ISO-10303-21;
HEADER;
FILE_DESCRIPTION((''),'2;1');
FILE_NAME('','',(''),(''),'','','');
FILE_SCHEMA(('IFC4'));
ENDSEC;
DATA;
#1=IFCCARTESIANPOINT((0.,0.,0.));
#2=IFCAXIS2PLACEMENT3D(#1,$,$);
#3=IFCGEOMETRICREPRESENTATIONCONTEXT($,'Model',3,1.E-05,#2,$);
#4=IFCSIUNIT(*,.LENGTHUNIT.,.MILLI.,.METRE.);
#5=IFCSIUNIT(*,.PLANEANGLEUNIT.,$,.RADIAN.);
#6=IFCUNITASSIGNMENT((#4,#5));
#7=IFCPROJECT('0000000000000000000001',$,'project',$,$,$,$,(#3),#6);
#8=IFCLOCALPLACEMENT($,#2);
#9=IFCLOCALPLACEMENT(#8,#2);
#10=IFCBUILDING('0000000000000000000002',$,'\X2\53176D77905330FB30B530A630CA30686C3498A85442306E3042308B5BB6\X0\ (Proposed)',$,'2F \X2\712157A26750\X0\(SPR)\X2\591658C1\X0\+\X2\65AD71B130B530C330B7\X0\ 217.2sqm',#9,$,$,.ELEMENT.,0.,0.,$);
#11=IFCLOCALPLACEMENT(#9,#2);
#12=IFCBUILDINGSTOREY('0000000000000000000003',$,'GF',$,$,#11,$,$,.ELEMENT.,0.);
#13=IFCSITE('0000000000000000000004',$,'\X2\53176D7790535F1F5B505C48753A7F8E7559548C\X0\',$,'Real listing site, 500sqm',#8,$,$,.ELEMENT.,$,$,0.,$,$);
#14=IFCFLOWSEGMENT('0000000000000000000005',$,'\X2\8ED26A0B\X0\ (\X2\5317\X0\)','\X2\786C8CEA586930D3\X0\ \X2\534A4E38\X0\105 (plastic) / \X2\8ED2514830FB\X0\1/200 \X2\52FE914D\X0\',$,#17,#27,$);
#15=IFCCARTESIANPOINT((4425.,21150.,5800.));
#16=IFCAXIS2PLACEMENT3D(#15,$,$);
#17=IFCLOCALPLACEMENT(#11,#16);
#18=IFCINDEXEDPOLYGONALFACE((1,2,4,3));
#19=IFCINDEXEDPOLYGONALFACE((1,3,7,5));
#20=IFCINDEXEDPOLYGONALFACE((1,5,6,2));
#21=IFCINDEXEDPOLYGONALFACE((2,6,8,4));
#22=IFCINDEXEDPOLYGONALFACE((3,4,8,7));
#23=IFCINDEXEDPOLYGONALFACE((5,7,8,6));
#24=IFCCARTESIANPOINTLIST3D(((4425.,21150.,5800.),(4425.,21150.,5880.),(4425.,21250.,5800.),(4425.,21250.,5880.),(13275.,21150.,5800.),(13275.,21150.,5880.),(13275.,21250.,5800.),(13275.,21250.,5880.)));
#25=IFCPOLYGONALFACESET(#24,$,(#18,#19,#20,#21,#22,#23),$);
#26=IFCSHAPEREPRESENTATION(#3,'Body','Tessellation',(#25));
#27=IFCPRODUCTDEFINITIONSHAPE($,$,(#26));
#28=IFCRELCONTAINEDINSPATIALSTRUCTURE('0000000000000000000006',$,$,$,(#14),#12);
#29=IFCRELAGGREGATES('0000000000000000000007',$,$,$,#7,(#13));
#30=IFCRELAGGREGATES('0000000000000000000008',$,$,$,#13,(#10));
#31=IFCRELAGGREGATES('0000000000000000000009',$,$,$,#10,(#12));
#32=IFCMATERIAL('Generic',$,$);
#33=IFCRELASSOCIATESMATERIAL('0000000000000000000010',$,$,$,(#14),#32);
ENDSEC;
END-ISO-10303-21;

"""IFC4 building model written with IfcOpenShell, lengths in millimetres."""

from ifc_helpers import new_model, si_unit, frame, frame_2d, origin, place, context, project, spatial, rectangle, extrude, material, element, save


model = new_model("IFC4")

# Units and contexts
model_context = context("Model", 3, precision=1e-05, world=origin())
ifc_project = project(units=[si_unit("LENGTHUNIT", "METRE", prefix="MILLI"), si_unit("PLANEANGLEUNIT", "RADIAN")], contexts=[model_context])

# Site, building, storey
site_placement = place(None, origin())
site = spatial("IfcSite", under=ifc_project, at=site_placement, Name="北海道弟子屈町美留和", ObjectType="Real listing site, 500sqm", CompositionType="ELEMENT", RefElevation=0.0)
building_placement = place(site_placement, origin())
building = spatial("IfcBuilding", under=site, at=building_placement, Name="北海道・サウナと水風呂のある家 (Proposed)", ObjectType="2F 無垢材(SPR)外壁+断熱サッシ 217.2sqm", CompositionType="ELEMENT", ElevationOfRefHeight=0.0, ElevationOfTerrain=0.0)
storey_placement = place(building_placement, origin())
storey = spatial("IfcBuildingStorey", under=building, at=storey_placement, Name="GF", CompositionType="ELEMENT", Elevation=0.0)

# Shared definitions
ifc_material_1 = material(Name="Generic")

# Flow segment
flow_segment_placement = place(storey_placement, frame((4425.0, 21150.0, 5800.0)))
element("IfcFlowSegment", 1, at=flow_segment_placement, inside=storey, material=ifc_material_1, Name="軒樋 (北)", Description="硬質塩ビ 半丸105 (plastic) / 軒先・1/200 勾配", context=model_context, shape_type="SweptSolid", body=[
    extrude(rectangle(XDim=8850.0, YDim=100.0, at=frame_2d((4425.0, 50.0))), frame((4425.0, 21150.0, 5800.0)), (0.0, 0.0, 1.0), 80.0),
])

save(model, "model.ifc")
